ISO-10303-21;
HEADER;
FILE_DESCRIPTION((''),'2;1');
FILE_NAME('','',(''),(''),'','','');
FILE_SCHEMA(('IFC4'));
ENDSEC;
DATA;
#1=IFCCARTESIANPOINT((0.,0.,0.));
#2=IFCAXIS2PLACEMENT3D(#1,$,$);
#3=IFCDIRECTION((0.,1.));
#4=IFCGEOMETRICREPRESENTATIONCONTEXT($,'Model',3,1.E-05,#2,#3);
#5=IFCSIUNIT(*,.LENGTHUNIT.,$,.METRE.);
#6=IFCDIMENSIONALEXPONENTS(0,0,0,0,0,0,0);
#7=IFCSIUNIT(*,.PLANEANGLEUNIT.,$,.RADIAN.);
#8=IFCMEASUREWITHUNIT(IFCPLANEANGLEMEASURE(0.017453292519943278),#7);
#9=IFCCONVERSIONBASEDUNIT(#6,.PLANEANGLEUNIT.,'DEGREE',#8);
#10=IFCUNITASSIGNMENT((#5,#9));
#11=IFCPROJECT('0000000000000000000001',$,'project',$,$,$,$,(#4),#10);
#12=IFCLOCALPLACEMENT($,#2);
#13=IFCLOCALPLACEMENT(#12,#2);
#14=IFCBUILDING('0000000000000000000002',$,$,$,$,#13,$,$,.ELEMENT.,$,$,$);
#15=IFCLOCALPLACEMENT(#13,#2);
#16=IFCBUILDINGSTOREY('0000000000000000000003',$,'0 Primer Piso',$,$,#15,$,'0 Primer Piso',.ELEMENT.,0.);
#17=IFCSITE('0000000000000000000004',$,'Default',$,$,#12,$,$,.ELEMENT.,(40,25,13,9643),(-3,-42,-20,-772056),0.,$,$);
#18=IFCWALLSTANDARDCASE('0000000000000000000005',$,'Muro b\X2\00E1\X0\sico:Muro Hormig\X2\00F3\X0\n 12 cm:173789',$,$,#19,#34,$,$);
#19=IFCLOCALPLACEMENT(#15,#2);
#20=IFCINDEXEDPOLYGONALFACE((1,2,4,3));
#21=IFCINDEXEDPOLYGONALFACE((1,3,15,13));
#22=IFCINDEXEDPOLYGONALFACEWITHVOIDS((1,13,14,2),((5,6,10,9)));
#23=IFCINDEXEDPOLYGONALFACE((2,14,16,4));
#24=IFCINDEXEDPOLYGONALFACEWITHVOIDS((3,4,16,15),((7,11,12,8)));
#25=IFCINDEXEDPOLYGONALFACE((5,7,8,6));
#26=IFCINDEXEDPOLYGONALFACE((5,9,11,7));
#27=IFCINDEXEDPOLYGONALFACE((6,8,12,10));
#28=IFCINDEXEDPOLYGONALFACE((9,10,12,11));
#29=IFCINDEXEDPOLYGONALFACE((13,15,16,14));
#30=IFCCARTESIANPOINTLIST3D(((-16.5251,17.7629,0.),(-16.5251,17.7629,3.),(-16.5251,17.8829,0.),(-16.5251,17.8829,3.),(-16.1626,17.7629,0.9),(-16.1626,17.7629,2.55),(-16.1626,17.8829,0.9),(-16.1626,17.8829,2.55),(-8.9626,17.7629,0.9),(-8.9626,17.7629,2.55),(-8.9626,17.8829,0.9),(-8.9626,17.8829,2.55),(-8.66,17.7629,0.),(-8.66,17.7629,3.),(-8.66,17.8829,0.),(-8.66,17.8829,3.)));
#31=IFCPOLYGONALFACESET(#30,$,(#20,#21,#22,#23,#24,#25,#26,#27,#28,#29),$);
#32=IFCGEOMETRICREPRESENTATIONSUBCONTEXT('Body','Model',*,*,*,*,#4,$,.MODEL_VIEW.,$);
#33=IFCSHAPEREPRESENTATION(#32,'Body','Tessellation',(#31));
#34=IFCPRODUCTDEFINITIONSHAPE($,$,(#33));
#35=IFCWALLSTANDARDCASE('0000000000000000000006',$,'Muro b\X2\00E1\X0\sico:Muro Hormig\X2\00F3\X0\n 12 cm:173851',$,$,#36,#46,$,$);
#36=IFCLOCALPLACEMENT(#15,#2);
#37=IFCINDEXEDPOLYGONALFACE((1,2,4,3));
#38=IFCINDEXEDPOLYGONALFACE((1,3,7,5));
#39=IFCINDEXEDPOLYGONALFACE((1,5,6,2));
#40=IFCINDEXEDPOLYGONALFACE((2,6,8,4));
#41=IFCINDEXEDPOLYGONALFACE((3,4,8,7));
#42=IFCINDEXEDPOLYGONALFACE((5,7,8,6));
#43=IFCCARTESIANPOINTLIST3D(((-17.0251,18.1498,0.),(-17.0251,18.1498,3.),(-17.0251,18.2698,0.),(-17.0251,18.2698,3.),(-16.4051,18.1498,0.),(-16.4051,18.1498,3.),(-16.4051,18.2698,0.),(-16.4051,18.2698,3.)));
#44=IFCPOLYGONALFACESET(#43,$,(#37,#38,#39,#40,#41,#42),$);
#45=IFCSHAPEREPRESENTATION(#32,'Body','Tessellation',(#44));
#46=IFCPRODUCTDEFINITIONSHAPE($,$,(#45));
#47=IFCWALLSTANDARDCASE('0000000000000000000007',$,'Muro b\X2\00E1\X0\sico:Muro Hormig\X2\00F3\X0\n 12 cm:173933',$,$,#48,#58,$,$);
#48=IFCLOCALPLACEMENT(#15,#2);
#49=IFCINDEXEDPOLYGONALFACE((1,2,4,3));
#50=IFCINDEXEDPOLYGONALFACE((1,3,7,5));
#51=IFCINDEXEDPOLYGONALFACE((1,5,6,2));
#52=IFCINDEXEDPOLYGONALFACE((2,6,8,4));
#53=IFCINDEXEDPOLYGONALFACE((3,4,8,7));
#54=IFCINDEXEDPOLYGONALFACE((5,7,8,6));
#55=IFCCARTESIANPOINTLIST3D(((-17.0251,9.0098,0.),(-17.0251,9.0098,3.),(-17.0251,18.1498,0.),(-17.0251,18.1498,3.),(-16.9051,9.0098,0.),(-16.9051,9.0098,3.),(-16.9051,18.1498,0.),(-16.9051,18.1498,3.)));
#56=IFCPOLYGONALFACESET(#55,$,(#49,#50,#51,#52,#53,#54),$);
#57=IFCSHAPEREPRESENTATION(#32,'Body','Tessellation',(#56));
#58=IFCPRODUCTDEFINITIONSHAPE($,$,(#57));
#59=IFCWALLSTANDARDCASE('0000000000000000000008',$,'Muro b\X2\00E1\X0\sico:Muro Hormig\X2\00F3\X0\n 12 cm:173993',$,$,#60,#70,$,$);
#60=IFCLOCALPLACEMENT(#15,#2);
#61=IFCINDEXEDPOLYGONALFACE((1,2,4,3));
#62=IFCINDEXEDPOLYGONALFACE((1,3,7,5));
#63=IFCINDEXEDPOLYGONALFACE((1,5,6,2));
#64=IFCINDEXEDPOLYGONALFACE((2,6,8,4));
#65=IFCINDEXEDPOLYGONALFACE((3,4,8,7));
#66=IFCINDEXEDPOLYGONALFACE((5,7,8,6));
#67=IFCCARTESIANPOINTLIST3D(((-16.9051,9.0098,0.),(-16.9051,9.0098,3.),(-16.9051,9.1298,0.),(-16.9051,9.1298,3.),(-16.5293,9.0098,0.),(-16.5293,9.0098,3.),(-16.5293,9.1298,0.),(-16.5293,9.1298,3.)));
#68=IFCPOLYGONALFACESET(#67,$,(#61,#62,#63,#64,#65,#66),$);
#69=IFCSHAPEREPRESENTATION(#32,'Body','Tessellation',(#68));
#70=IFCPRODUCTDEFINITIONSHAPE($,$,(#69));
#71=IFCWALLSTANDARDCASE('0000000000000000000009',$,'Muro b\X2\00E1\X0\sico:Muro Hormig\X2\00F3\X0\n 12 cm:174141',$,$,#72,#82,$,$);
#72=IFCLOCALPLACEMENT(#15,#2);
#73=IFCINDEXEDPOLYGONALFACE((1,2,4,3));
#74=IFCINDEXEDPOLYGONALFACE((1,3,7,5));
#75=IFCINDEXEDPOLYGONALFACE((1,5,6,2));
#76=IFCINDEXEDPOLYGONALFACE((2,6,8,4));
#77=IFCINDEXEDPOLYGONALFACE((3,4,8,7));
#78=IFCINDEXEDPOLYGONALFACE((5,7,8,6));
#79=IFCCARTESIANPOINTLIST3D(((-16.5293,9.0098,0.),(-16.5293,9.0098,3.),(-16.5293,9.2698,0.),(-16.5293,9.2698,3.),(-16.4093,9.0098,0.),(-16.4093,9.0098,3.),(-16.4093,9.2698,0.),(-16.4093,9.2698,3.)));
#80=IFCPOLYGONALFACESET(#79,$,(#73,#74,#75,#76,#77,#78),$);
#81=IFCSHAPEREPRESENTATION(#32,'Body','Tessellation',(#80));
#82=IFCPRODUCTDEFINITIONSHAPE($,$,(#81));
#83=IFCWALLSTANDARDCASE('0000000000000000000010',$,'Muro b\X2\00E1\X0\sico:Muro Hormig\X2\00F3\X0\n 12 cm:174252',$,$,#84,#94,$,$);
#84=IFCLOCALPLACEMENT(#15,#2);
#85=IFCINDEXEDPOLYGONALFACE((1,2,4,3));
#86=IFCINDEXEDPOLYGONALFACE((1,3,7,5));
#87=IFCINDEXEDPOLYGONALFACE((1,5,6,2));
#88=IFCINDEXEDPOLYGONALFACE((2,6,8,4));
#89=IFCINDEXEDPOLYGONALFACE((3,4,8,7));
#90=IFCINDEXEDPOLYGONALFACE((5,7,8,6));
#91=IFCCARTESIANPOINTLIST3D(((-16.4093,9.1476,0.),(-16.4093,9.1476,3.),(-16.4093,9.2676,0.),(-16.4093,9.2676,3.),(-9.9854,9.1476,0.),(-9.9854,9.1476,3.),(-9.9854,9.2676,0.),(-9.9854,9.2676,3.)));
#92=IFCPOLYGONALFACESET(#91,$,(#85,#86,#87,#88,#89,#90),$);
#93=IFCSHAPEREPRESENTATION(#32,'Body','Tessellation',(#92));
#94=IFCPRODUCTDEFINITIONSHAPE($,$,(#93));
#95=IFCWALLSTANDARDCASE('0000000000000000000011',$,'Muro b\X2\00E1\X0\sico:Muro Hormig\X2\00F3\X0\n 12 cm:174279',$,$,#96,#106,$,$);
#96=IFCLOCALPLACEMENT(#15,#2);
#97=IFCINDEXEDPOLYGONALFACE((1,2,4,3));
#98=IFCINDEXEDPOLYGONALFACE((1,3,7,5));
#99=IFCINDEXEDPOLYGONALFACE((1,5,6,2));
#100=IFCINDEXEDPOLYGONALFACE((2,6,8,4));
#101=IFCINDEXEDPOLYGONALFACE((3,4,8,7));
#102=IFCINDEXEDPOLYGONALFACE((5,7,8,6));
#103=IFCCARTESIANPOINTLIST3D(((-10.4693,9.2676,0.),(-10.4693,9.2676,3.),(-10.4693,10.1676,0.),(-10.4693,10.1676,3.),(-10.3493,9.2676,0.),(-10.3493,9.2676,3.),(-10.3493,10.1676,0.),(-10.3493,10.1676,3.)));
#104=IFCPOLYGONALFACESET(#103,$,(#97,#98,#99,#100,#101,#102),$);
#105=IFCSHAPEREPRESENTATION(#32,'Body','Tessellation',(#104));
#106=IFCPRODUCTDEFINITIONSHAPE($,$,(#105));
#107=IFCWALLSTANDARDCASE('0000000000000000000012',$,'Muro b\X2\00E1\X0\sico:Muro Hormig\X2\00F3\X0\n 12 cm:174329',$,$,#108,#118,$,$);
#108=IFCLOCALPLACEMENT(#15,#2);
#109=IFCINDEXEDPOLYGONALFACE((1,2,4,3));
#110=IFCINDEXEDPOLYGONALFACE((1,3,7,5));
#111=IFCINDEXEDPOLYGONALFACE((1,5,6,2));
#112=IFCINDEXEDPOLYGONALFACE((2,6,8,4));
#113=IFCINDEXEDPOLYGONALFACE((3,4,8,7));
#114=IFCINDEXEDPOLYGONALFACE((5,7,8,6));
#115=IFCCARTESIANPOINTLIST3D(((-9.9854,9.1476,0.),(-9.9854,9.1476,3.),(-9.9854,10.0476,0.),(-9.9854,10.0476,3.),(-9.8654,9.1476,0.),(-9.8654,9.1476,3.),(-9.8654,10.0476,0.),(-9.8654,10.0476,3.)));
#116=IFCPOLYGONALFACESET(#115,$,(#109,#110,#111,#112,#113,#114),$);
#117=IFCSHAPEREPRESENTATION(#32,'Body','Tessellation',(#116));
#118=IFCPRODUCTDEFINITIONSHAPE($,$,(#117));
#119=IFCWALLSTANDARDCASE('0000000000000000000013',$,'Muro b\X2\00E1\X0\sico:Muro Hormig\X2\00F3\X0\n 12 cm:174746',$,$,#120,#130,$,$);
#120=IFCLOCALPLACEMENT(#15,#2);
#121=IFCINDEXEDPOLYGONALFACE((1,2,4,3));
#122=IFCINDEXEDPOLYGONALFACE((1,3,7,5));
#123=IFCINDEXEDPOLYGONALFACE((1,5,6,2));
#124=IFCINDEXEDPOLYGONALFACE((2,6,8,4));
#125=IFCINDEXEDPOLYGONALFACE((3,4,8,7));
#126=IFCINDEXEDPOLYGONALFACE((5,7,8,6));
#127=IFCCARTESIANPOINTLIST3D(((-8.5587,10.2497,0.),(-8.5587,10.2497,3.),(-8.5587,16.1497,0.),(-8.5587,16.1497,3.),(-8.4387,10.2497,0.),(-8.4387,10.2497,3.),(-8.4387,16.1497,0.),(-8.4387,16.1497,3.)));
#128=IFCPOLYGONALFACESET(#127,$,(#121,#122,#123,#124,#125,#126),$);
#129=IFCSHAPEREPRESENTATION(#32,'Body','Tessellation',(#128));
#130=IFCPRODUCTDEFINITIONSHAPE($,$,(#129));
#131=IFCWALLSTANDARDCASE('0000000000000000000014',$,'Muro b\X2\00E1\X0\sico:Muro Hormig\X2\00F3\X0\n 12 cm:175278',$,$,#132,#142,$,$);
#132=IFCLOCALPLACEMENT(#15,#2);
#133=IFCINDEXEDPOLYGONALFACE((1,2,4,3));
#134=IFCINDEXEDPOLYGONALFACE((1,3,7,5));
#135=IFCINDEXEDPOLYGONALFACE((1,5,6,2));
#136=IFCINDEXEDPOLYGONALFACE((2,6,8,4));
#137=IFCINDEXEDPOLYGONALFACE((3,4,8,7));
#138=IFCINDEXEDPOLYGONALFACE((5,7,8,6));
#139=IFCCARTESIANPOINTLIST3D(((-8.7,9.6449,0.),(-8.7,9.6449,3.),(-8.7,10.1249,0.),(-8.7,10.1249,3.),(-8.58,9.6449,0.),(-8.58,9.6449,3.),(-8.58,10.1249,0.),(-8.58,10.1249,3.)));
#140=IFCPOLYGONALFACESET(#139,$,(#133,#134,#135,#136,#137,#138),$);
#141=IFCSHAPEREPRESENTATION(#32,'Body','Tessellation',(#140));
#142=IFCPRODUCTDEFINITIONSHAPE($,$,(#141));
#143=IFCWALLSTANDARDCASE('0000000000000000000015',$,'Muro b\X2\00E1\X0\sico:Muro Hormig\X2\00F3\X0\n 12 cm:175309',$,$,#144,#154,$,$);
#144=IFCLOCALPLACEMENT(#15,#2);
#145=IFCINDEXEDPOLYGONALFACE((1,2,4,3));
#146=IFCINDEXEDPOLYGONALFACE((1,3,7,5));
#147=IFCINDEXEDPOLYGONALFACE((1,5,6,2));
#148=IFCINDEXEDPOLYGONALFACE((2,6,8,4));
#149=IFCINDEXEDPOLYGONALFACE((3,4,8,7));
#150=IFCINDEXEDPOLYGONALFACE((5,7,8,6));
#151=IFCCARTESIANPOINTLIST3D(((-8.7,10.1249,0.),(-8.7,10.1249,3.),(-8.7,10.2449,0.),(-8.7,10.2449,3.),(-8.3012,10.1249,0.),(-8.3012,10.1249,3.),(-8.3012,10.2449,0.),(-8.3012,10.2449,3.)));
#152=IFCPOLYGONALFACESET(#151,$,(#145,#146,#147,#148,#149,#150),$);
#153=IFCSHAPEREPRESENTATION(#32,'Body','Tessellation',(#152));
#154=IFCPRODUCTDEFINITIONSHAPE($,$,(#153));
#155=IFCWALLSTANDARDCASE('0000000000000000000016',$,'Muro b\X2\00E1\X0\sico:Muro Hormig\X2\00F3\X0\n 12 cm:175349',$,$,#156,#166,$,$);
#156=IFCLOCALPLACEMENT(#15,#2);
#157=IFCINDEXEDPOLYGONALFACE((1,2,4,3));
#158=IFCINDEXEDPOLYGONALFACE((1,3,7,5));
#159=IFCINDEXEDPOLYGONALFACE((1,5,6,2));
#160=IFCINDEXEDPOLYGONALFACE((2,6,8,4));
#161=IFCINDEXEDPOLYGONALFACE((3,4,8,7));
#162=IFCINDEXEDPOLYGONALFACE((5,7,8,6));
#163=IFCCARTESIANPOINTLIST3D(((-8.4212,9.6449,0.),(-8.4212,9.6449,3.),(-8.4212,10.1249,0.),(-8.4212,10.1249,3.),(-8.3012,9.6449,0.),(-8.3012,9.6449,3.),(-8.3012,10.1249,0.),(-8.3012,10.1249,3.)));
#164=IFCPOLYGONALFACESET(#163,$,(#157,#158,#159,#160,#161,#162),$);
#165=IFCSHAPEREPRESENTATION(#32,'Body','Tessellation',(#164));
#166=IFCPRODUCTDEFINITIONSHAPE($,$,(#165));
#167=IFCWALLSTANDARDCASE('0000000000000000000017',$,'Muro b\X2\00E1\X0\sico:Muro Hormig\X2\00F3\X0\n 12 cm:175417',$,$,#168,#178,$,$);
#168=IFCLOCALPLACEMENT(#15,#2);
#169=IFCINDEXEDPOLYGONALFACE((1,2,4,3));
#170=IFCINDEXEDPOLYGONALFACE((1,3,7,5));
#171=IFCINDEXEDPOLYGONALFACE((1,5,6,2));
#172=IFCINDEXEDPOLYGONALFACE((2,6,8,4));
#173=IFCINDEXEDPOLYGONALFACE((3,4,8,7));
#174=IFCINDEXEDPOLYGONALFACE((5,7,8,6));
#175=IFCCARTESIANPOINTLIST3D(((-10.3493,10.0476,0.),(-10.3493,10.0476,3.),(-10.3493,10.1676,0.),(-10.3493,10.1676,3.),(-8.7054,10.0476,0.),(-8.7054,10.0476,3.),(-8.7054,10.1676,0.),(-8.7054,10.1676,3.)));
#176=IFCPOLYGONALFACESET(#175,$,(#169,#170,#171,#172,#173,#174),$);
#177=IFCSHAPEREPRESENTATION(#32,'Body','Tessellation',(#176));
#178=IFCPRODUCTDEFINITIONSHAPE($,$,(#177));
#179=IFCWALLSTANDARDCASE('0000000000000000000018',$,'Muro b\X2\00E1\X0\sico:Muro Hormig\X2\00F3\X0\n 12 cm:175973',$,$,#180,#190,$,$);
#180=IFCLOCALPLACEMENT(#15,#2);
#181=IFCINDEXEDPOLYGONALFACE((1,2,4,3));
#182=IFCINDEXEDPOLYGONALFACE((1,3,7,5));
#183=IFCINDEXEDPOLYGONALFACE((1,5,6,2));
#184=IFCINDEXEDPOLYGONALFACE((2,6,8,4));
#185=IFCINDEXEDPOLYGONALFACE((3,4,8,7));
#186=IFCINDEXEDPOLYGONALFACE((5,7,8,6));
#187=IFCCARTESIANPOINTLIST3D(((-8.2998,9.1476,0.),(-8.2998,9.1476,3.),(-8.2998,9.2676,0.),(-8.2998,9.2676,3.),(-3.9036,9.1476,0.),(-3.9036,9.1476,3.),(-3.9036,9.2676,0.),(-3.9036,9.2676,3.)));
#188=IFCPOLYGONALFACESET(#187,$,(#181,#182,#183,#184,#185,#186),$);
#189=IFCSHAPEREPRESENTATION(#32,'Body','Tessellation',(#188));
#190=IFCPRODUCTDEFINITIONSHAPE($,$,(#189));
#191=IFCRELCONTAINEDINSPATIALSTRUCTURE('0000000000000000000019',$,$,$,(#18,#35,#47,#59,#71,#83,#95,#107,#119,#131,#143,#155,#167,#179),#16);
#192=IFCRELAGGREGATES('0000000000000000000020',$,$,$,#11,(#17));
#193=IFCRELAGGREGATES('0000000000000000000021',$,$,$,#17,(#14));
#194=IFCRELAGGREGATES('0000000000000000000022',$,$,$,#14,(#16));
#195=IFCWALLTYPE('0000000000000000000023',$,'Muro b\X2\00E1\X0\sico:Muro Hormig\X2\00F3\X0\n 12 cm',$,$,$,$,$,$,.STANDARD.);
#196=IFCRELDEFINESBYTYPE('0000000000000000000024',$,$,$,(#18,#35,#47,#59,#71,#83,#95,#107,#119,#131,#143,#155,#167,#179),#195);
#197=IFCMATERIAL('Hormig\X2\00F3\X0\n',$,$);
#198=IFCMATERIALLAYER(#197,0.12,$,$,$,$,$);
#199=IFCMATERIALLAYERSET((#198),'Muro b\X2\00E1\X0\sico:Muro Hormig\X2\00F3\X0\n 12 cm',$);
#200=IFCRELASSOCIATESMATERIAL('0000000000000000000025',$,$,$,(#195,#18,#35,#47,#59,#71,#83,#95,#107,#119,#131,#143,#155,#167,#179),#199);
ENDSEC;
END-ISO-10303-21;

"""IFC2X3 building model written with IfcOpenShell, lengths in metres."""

from ifc_helpers import new_model, entity, si_unit, converted_unit, direction, frame, frame_2d, origin, place, context, subcontext, project, spatial, rectangle, extrude, material, layer, layer_set, layer_usage, type_object, element, save


model = new_model("IFC2X3")

# Units and contexts
model_context = context("Model", 3, precision=1e-05, world=origin(), true_north=direction((0.0, 1.0)))
body_context = subcontext(model_context, "Body", "Model", "MODEL_VIEW")
ifc_project = project(units=[si_unit("LENGTHUNIT", "METRE"), converted_unit("PLANEANGLEUNIT", "DEGREE", entity("IfcPlaneAngleMeasure", 0.017453292519943278), si_unit("PLANEANGLEUNIT", "RADIAN"), dimensions=[0, 0, 0, 0, 0, 0, 0])], contexts=[model_context])

# Site, building, storey
site_placement = place(None, origin())
site = spatial("IfcSite", under=ifc_project, at=site_placement, Name="Default", CompositionType="ELEMENT", RefLatitude=(40, 25, 13, 9643), RefLongitude=(-3, -42, -20, -772056), RefElevation=0.0)
building_placement = place(site_placement, origin())
building = spatial("IfcBuilding", under=site, at=building_placement, CompositionType="ELEMENT")
storey_placement = place(building_placement, origin())
storey = spatial("IfcBuildingStorey", under=building, at=storey_placement, Name="0 Primer Piso", LongName="0 Primer Piso", CompositionType="ELEMENT", Elevation=0.0)

# Wall, opening
ifc_material = material(Name="Hormigón")
ifc_layer = layer(ifc_material, 0.12)
ifc_layer_set = layer_set([ifc_layer], Name="Muro básico:Muro Hormigón 12 cm")
ifc_layer_usage_1 = layer_usage(ifc_layer_set, "AXIS2", "NEGATIVE", 0.06)
wall_type = type_object("IfcWallType", Name="Muro básico:Muro Hormigón 12 cm", PredefinedType="STANDARD", material=ifc_layer_set)
wall_1_placement = place(storey_placement, frame((-16.5251, 17.8229, 0.0)))
wall_1 = element("IfcWallStandardCase", 1, at=wall_1_placement, inside=storey, type_object=wall_type, material=ifc_layer_usage_1, Name="Muro básico:Muro Hormigón 12 cm:173789", context=body_context, shape_type="SweptSolid", body=[
    extrude(rectangle(XDim=7.8652, YDim=0.12, at=frame_2d((3.9326, 0.0), x_axis=(-1.0, 0.0))), origin(), (0.0, 0.0, 1.0), 3.0),
])
opening_1_placement = place(wall_1_placement, frame((7.5626, 0.06, 0.9)))
element("IfcOpeningElement", 2, at=opening_1_placement, cuts=wall_1, ObjectType="Opening", context=body_context, shape_type="SweptSolid", body=[
    extrude(rectangle(XDim=1.65, YDim=7.2, at=frame_2d((0.825, 3.6), x_axis=(1.0, 0.0))), frame((0.0, 0.0, 0.0), z_axis=(0.0, -1.0, 0.0), x_axis=(0.0, 0.0, 1.0)), (0.0, 0.0, 1.0), 0.12),
])

# Walls
ifc_layer_usage_2 = layer_usage(ifc_layer_set, "AXIS2", "NEGATIVE", 0.06)
wall_2_placement = place(storey_placement, frame((-16.4051, 18.2098, 0.0), z_axis=(0.0, 0.0, 1.0), x_axis=(-1.0, 0.0, 0.0)))
element("IfcWallStandardCase", 3, at=wall_2_placement, inside=storey, type_object=wall_type, material=ifc_layer_usage_2, Name="Muro básico:Muro Hormigón 12 cm:173851", context=body_context, shape_type="SweptSolid", body=[
    extrude(rectangle(XDim=0.62, YDim=0.12, at=frame_2d((0.31, 0.0), x_axis=(-1.0, 0.0))), origin(), (0.0, 0.0, 1.0), 3.0),
])
ifc_layer_usage_3 = layer_usage(ifc_layer_set, "AXIS2", "NEGATIVE", 0.06)
wall_3_placement = place(storey_placement, frame((-16.9651, 18.1498, 0.0), z_axis=(0.0, 0.0, 1.0), x_axis=(0.0, -1.0, 0.0)))
element("IfcWallStandardCase", 4, at=wall_3_placement, inside=storey, type_object=wall_type, material=ifc_layer_usage_3, Name="Muro básico:Muro Hormigón 12 cm:173933", context=body_context, shape_type="SweptSolid", body=[
    extrude(rectangle(XDim=9.14, YDim=0.12, at=frame_2d((4.57, 0.0), x_axis=(-1.0, 0.0))), origin(), (0.0, 0.0, 1.0), 3.0),
])
ifc_layer_usage_4 = layer_usage(ifc_layer_set, "AXIS2", "NEGATIVE", 0.06)
wall_4_placement = place(storey_placement, frame((-16.9051, 9.0698, 0.0)))
element("IfcWallStandardCase", 5, at=wall_4_placement, inside=storey, type_object=wall_type, material=ifc_layer_usage_4, Name="Muro básico:Muro Hormigón 12 cm:173993", context=body_context, shape_type="SweptSolid", body=[
    extrude(rectangle(XDim=0.3758, YDim=0.12, at=frame_2d((0.1879, 0.0), x_axis=(-1.0, 0.0))), origin(), (0.0, 0.0, 1.0), 3.0),
])
ifc_layer_usage_5 = layer_usage(ifc_layer_set, "AXIS2", "NEGATIVE", 0.06)
wall_5_placement = place(storey_placement, frame((-16.4693, 9.0098, 0.0), z_axis=(0.0, 0.0, 1.0), x_axis=(0.0, 1.0, 0.0)))
element("IfcWallStandardCase", 6, at=wall_5_placement, inside=storey, type_object=wall_type, material=ifc_layer_usage_5, Name="Muro básico:Muro Hormigón 12 cm:174141", context=body_context, shape_type="SweptSolid", body=[
    extrude(rectangle(XDim=0.26, YDim=0.12, at=frame_2d((0.13, 0.0), x_axis=(-1.0, 0.0))), origin(), (0.0, 0.0, 1.0), 3.0),
])
ifc_layer_usage_6 = layer_usage(ifc_layer_set, "AXIS2", "NEGATIVE", 0.06)
wall_6_placement = place(storey_placement, frame((-16.4093, 9.2076, 0.0)))
element("IfcWallStandardCase", 7, at=wall_6_placement, inside=storey, type_object=wall_type, material=ifc_layer_usage_6, Name="Muro básico:Muro Hormigón 12 cm:174252", context=body_context, shape_type="SweptSolid", body=[
    extrude(rectangle(XDim=6.4239, YDim=0.12, at=frame_2d((3.212, 0.0), x_axis=(-1.0, 0.0))), origin(), (0.0, 0.0, 1.0), 3.0),
])
ifc_layer_usage_7 = layer_usage(ifc_layer_set, "AXIS2", "NEGATIVE", 0.06)
wall_7_placement = place(storey_placement, frame((-10.4093, 9.2676, 0.0), z_axis=(0.0, 0.0, 1.0), x_axis=(0.0, 1.0, 0.0)))
element("IfcWallStandardCase", 8, at=wall_7_placement, inside=storey, type_object=wall_type, material=ifc_layer_usage_7, Name="Muro básico:Muro Hormigón 12 cm:174279", context=body_context, shape_type="SweptSolid", body=[
    extrude(rectangle(XDim=0.9, YDim=0.12, at=frame_2d((0.45, 0.0), x_axis=(-1.0, 0.0))), origin(), (0.0, 0.0, 1.0), 3.0),
])
ifc_layer_usage_8 = layer_usage(ifc_layer_set, "AXIS2", "NEGATIVE", 0.06)
wall_8_placement = place(storey_placement, frame((-9.9254, 10.0476, 0.0), z_axis=(0.0, 0.0, 1.0), x_axis=(0.0, -1.0, 0.0)))
element("IfcWallStandardCase", 9, at=wall_8_placement, inside=storey, type_object=wall_type, material=ifc_layer_usage_8, Name="Muro básico:Muro Hormigón 12 cm:174329", context=body_context, shape_type="SweptSolid", body=[
    extrude(rectangle(XDim=0.9, YDim=0.12, at=frame_2d((0.45, 0.0), x_axis=(-1.0, 0.0))), origin(), (0.0, 0.0, 1.0), 3.0),
])
ifc_layer_usage_9 = layer_usage(ifc_layer_set, "AXIS2", "NEGATIVE", 0.06)
wall_9_placement = place(storey_placement, frame((-8.4987, 16.1497, 0.0), z_axis=(0.0, 0.0, 1.0), x_axis=(0.0, -1.0, 0.0)))
element("IfcWallStandardCase", 10, at=wall_9_placement, inside=storey, type_object=wall_type, material=ifc_layer_usage_9, Name="Muro básico:Muro Hormigón 12 cm:174746", context=body_context, shape_type="SweptSolid", body=[
    extrude(rectangle(XDim=5.9, YDim=0.12, at=frame_2d((2.95, 0.0), x_axis=(-1.0, 0.0))), origin(), (0.0, 0.0, 1.0), 3.0),
])
ifc_layer_usage_10 = layer_usage(ifc_layer_set, "AXIS2", "NEGATIVE", 0.06)
wall_10_placement = place(storey_placement, frame((-8.64, 9.6449, 0.0), z_axis=(0.0, 0.0, 1.0), x_axis=(0.0, 1.0, 0.0)))
element("IfcWallStandardCase", 11, at=wall_10_placement, inside=storey, type_object=wall_type, material=ifc_layer_usage_10, Name="Muro básico:Muro Hormigón 12 cm:175278", context=body_context, shape_type="SweptSolid", body=[
    extrude(rectangle(XDim=0.48, YDim=0.12, at=frame_2d((0.24, 0.0), x_axis=(-1.0, 0.0))), origin(), (0.0, 0.0, 1.0), 3.0),
])
ifc_layer_usage_11 = layer_usage(ifc_layer_set, "AXIS2", "NEGATIVE", 0.06)
wall_11_placement = place(storey_placement, frame((-8.7, 10.1849, 0.0)))
element("IfcWallStandardCase", 12, at=wall_11_placement, inside=storey, type_object=wall_type, material=ifc_layer_usage_11, Name="Muro básico:Muro Hormigón 12 cm:175309", context=body_context, shape_type="SweptSolid", body=[
    extrude(rectangle(XDim=0.3988, YDim=0.12, at=frame_2d((0.1994, 0.0), x_axis=(-1.0, 0.0))), origin(), (0.0, 0.0, 1.0), 3.0),
])
ifc_layer_usage_12 = layer_usage(ifc_layer_set, "AXIS2", "NEGATIVE", 0.06)
wall_12_placement = place(storey_placement, frame((-8.3612, 10.1249, 0.0), z_axis=(0.0, 0.0, 1.0), x_axis=(0.0, -1.0, 0.0)))
element("IfcWallStandardCase", 13, at=wall_12_placement, inside=storey, type_object=wall_type, material=ifc_layer_usage_12, Name="Muro básico:Muro Hormigón 12 cm:175349", context=body_context, shape_type="SweptSolid", body=[
    extrude(rectangle(XDim=0.48, YDim=0.12, at=frame_2d((0.24, 0.0), x_axis=(-1.0, 0.0))), origin(), (0.0, 0.0, 1.0), 3.0),
])
ifc_layer_usage_13 = layer_usage(ifc_layer_set, "AXIS2", "NEGATIVE", 0.06)
wall_13_placement = place(storey_placement, frame((-10.3493, 10.1076, 0.0)))
element("IfcWallStandardCase", 14, at=wall_13_placement, inside=storey, type_object=wall_type, material=ifc_layer_usage_13, Name="Muro básico:Muro Hormigón 12 cm:175417", context=body_context, shape_type="SweptSolid", body=[
    extrude(rectangle(XDim=1.6439, YDim=0.12, at=frame_2d((0.822, 0.0), x_axis=(-1.0, 0.0))), origin(), (0.0, 0.0, 1.0), 3.0),
])
ifc_layer_usage_14 = layer_usage(ifc_layer_set, "AXIS2", "NEGATIVE", 0.06)
wall_14_placement = place(storey_placement, frame((-8.2998, 9.2076, 0.0)))
element("IfcWallStandardCase", 15, at=wall_14_placement, inside=storey, type_object=wall_type, material=ifc_layer_usage_14, Name="Muro básico:Muro Hormigón 12 cm:175973", context=body_context, shape_type="SweptSolid", body=[
    extrude(rectangle(XDim=4.3962, YDim=0.12, at=frame_2d((2.1981, 0.0), x_axis=(-1.0, 0.0))), origin(), (0.0, 0.0, 1.0), 3.0),
])

save(model, "model.ifc")
